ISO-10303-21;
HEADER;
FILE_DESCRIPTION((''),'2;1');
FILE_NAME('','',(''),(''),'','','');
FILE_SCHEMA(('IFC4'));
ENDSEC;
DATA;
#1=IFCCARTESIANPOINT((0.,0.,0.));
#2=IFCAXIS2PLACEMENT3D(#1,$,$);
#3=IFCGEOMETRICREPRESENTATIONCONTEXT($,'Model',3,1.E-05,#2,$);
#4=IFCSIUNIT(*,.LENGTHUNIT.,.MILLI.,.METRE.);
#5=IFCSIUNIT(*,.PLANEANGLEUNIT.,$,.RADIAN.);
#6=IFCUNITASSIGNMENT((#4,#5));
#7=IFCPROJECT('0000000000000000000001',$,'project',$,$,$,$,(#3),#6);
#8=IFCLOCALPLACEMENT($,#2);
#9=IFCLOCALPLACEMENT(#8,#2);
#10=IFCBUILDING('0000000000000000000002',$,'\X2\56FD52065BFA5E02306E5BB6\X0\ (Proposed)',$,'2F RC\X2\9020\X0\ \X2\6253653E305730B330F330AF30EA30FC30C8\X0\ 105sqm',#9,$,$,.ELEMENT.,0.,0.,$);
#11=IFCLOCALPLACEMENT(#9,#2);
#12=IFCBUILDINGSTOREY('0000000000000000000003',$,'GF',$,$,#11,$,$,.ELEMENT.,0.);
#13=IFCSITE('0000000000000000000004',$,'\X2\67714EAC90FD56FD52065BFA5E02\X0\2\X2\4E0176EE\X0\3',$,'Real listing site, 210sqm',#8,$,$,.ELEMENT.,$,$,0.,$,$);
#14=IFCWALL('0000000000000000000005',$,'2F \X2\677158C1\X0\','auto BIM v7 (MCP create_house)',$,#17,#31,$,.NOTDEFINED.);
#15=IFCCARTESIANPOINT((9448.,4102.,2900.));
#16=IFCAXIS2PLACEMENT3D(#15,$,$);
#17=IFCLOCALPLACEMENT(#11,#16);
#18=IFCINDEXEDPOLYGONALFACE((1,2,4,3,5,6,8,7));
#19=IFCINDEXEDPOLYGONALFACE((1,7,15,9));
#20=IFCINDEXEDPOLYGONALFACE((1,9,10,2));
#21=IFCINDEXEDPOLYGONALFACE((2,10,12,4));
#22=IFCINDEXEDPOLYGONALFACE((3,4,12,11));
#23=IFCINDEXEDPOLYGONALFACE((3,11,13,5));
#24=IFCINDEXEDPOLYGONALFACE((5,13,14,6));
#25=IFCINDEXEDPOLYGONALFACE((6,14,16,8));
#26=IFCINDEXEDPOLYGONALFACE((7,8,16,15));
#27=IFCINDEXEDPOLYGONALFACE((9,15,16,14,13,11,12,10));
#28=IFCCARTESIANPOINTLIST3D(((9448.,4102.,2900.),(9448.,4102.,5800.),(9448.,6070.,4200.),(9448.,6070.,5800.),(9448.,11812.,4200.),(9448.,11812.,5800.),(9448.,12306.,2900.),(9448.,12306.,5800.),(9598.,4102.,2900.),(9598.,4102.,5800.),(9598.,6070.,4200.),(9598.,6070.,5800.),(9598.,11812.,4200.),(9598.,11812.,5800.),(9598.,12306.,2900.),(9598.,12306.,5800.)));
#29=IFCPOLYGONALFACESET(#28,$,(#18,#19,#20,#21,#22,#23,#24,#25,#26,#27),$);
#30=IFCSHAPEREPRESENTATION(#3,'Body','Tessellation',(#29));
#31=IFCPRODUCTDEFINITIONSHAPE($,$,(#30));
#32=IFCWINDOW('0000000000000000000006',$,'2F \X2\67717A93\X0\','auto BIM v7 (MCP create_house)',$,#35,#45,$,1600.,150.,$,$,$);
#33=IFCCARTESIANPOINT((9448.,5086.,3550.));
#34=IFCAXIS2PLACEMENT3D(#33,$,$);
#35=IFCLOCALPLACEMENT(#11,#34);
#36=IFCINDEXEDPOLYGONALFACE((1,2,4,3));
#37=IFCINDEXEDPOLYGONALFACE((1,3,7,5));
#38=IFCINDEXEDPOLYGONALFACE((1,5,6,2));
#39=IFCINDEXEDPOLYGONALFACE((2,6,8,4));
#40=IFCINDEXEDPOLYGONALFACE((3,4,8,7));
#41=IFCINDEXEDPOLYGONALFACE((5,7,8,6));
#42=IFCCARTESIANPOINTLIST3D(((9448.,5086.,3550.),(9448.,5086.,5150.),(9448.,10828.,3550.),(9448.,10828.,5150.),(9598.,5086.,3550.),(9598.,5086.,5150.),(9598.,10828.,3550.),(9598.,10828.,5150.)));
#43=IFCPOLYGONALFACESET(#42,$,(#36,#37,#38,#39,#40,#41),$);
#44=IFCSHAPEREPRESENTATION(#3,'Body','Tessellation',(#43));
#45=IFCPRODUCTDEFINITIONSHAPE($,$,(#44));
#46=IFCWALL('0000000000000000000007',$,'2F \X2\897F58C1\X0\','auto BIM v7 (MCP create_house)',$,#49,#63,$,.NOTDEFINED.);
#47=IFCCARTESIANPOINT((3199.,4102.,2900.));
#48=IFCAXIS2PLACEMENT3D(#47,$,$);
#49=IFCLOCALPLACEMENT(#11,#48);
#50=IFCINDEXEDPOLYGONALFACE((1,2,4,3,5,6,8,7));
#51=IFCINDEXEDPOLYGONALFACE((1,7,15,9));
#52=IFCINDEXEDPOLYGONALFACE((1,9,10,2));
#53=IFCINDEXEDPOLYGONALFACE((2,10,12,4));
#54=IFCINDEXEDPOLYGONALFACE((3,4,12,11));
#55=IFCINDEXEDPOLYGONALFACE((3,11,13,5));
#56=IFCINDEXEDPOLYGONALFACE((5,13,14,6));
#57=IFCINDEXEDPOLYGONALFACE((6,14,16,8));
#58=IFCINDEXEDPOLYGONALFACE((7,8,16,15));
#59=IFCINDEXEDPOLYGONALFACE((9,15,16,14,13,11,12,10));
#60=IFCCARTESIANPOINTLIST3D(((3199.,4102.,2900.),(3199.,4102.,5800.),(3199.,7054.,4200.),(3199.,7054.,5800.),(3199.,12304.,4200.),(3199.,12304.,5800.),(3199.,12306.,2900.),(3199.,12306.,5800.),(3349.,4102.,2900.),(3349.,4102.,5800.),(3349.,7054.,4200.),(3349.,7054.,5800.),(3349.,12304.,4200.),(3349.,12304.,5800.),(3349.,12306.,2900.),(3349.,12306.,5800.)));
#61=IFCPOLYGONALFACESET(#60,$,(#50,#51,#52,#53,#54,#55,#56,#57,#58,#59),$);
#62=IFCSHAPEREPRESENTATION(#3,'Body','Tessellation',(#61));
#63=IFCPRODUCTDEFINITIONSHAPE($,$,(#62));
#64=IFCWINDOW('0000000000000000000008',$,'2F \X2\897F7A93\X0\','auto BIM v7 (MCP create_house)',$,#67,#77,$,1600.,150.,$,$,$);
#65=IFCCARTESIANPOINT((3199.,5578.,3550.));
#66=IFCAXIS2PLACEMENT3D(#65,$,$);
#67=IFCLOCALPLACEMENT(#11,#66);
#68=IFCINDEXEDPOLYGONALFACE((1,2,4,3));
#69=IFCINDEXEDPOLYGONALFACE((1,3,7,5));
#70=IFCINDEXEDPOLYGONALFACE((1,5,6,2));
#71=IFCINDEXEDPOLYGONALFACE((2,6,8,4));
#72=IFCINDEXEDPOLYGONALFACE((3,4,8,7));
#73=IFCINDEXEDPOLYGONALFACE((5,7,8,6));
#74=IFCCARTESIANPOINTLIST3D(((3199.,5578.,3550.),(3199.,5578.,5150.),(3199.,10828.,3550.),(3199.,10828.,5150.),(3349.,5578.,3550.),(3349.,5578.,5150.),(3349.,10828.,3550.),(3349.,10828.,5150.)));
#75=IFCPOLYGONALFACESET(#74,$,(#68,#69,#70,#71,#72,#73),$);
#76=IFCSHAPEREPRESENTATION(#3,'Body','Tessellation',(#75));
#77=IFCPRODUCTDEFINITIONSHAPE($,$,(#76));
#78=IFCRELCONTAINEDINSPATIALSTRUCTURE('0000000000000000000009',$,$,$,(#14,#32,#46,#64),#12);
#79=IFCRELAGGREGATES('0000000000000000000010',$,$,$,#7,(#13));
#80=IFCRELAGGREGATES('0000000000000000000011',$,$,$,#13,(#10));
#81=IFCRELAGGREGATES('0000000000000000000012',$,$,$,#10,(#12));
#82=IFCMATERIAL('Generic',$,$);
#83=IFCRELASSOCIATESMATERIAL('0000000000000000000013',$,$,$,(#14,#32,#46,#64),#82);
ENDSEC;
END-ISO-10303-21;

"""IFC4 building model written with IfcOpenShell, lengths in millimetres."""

from ifc_helpers import new_model, si_unit, frame, frame_2d, origin, place, context, project, spatial, rectangle, extrude, material, element, fill, save


model = new_model("IFC4")

# Units and contexts
model_context = context("Model", 3, precision=1e-05, world=origin())
ifc_project = project(units=[si_unit("LENGTHUNIT", "METRE", prefix="MILLI"), si_unit("PLANEANGLEUNIT", "RADIAN")], contexts=[model_context])

# Site, building, storey
site_placement = place(None, origin())
site = spatial("IfcSite", under=ifc_project, at=site_placement, Name="東京都国分寺市2丁目3", ObjectType="Real listing site, 210sqm", CompositionType="ELEMENT", RefElevation=0.0)
building_placement = place(site_placement, origin())
building = spatial("IfcBuilding", under=site, at=building_placement, Name="国分寺市の家 (Proposed)", ObjectType="2F RC造 打放しコンクリート 105sqm", CompositionType="ELEMENT", ElevationOfRefHeight=0.0, ElevationOfTerrain=0.0)
storey_placement = place(building_placement, origin())
storey = spatial("IfcBuildingStorey", under=building, at=storey_placement, Name="GF", CompositionType="ELEMENT", Elevation=0.0)

# Shared definitions
ifc_material = material(Name="Generic")

# Walls, openings, windows
wall_1_placement = place(storey_placement, frame((9448.0, 4102.0, 2900.0)))
wall_1 = element("IfcWall", 1, at=wall_1_placement, inside=storey, material=ifc_material, Name="2F 東壁", Description="auto BIM v7 (MCP create_house)", PredefinedType="NOTDEFINED", context=model_context, shape_type="SweptSolid", body=[
    extrude(rectangle(XDim=150.0, YDim=8204.0, at=frame_2d((75.0, 4102.0))), frame((9448.0, 4102.0, 2900.0)), (0.0, 0.0, 1.0), 2900.0),
])
opening_1_placement = place(storey_placement, frame((9448.0, 5086.0, 3550.0)))
opening_1 = element("IfcOpeningElement", 2, at=opening_1_placement, cuts=wall_1, PredefinedType="NOTDEFINED", context=model_context, shape_type="SweptSolid", body=[
    extrude(rectangle(XDim=150.0, YDim=5742.0, at=frame_2d((75.0, 2871.0))), frame((9448.0, 5086.0, 3550.0)), (0.0, 0.0, 1.0), 1600.0),
])
window_1_placement = place(storey_placement, frame((9448.0, 5086.0, 3550.0)))
window_1 = element("IfcWindow", 3, at=window_1_placement, inside=storey, material=ifc_material, Name="2F 東窓", Description="auto BIM v7 (MCP create_house)", OverallHeight=1600.0, OverallWidth=150.0, context=model_context, shape_type="SweptSolid", body=[
    extrude(rectangle(XDim=150.0, YDim=5742.0, at=frame_2d((75.0, 2871.0))), frame((9448.0, 5086.0, 3550.0)), (0.0, 0.0, 1.0), 1600.0),
])
fill(opening_1, window_1)
wall_2_placement = place(storey_placement, frame((3199.0, 4102.0, 2900.0)))
wall_2 = element("IfcWall", 4, at=wall_2_placement, inside=storey, material=ifc_material, Name="2F 西壁", Description="auto BIM v7 (MCP create_house)", PredefinedType="NOTDEFINED", context=model_context, shape_type="SweptSolid", body=[
    extrude(rectangle(XDim=150.0, YDim=8204.0, at=frame_2d((75.0, 4102.0))), frame((3199.0, 4102.0, 2900.0)), (0.0, 0.0, 1.0), 2900.0),
])
opening_2_placement = place(storey_placement, frame((3199.0, 5578.0, 3550.0)))
opening_2 = element("IfcOpeningElement", 5, at=opening_2_placement, cuts=wall_2, PredefinedType="NOTDEFINED", context=model_context, shape_type="SweptSolid", body=[
    extrude(rectangle(XDim=150.0, YDim=5250.0, at=frame_2d((75.0, 2625.0))), frame((3199.0, 5578.0, 3550.0)), (0.0, 0.0, 1.0), 1600.0),
])
window_2_placement = place(storey_placement, frame((3199.0, 5578.0, 3550.0)))
window_2 = element("IfcWindow", 6, at=window_2_placement, inside=storey, material=ifc_material, Name="2F 西窓", Description="auto BIM v7 (MCP create_house)", OverallHeight=1600.0, OverallWidth=150.0, context=model_context, shape_type="SweptSolid", body=[
    extrude(rectangle(XDim=150.0, YDim=5250.0, at=frame_2d((75.0, 2625.0))), frame((3199.0, 5578.0, 3550.0)), (0.0, 0.0, 1.0), 1600.0),
])
fill(opening_2, window_2)

save(model, "model.ifc")
